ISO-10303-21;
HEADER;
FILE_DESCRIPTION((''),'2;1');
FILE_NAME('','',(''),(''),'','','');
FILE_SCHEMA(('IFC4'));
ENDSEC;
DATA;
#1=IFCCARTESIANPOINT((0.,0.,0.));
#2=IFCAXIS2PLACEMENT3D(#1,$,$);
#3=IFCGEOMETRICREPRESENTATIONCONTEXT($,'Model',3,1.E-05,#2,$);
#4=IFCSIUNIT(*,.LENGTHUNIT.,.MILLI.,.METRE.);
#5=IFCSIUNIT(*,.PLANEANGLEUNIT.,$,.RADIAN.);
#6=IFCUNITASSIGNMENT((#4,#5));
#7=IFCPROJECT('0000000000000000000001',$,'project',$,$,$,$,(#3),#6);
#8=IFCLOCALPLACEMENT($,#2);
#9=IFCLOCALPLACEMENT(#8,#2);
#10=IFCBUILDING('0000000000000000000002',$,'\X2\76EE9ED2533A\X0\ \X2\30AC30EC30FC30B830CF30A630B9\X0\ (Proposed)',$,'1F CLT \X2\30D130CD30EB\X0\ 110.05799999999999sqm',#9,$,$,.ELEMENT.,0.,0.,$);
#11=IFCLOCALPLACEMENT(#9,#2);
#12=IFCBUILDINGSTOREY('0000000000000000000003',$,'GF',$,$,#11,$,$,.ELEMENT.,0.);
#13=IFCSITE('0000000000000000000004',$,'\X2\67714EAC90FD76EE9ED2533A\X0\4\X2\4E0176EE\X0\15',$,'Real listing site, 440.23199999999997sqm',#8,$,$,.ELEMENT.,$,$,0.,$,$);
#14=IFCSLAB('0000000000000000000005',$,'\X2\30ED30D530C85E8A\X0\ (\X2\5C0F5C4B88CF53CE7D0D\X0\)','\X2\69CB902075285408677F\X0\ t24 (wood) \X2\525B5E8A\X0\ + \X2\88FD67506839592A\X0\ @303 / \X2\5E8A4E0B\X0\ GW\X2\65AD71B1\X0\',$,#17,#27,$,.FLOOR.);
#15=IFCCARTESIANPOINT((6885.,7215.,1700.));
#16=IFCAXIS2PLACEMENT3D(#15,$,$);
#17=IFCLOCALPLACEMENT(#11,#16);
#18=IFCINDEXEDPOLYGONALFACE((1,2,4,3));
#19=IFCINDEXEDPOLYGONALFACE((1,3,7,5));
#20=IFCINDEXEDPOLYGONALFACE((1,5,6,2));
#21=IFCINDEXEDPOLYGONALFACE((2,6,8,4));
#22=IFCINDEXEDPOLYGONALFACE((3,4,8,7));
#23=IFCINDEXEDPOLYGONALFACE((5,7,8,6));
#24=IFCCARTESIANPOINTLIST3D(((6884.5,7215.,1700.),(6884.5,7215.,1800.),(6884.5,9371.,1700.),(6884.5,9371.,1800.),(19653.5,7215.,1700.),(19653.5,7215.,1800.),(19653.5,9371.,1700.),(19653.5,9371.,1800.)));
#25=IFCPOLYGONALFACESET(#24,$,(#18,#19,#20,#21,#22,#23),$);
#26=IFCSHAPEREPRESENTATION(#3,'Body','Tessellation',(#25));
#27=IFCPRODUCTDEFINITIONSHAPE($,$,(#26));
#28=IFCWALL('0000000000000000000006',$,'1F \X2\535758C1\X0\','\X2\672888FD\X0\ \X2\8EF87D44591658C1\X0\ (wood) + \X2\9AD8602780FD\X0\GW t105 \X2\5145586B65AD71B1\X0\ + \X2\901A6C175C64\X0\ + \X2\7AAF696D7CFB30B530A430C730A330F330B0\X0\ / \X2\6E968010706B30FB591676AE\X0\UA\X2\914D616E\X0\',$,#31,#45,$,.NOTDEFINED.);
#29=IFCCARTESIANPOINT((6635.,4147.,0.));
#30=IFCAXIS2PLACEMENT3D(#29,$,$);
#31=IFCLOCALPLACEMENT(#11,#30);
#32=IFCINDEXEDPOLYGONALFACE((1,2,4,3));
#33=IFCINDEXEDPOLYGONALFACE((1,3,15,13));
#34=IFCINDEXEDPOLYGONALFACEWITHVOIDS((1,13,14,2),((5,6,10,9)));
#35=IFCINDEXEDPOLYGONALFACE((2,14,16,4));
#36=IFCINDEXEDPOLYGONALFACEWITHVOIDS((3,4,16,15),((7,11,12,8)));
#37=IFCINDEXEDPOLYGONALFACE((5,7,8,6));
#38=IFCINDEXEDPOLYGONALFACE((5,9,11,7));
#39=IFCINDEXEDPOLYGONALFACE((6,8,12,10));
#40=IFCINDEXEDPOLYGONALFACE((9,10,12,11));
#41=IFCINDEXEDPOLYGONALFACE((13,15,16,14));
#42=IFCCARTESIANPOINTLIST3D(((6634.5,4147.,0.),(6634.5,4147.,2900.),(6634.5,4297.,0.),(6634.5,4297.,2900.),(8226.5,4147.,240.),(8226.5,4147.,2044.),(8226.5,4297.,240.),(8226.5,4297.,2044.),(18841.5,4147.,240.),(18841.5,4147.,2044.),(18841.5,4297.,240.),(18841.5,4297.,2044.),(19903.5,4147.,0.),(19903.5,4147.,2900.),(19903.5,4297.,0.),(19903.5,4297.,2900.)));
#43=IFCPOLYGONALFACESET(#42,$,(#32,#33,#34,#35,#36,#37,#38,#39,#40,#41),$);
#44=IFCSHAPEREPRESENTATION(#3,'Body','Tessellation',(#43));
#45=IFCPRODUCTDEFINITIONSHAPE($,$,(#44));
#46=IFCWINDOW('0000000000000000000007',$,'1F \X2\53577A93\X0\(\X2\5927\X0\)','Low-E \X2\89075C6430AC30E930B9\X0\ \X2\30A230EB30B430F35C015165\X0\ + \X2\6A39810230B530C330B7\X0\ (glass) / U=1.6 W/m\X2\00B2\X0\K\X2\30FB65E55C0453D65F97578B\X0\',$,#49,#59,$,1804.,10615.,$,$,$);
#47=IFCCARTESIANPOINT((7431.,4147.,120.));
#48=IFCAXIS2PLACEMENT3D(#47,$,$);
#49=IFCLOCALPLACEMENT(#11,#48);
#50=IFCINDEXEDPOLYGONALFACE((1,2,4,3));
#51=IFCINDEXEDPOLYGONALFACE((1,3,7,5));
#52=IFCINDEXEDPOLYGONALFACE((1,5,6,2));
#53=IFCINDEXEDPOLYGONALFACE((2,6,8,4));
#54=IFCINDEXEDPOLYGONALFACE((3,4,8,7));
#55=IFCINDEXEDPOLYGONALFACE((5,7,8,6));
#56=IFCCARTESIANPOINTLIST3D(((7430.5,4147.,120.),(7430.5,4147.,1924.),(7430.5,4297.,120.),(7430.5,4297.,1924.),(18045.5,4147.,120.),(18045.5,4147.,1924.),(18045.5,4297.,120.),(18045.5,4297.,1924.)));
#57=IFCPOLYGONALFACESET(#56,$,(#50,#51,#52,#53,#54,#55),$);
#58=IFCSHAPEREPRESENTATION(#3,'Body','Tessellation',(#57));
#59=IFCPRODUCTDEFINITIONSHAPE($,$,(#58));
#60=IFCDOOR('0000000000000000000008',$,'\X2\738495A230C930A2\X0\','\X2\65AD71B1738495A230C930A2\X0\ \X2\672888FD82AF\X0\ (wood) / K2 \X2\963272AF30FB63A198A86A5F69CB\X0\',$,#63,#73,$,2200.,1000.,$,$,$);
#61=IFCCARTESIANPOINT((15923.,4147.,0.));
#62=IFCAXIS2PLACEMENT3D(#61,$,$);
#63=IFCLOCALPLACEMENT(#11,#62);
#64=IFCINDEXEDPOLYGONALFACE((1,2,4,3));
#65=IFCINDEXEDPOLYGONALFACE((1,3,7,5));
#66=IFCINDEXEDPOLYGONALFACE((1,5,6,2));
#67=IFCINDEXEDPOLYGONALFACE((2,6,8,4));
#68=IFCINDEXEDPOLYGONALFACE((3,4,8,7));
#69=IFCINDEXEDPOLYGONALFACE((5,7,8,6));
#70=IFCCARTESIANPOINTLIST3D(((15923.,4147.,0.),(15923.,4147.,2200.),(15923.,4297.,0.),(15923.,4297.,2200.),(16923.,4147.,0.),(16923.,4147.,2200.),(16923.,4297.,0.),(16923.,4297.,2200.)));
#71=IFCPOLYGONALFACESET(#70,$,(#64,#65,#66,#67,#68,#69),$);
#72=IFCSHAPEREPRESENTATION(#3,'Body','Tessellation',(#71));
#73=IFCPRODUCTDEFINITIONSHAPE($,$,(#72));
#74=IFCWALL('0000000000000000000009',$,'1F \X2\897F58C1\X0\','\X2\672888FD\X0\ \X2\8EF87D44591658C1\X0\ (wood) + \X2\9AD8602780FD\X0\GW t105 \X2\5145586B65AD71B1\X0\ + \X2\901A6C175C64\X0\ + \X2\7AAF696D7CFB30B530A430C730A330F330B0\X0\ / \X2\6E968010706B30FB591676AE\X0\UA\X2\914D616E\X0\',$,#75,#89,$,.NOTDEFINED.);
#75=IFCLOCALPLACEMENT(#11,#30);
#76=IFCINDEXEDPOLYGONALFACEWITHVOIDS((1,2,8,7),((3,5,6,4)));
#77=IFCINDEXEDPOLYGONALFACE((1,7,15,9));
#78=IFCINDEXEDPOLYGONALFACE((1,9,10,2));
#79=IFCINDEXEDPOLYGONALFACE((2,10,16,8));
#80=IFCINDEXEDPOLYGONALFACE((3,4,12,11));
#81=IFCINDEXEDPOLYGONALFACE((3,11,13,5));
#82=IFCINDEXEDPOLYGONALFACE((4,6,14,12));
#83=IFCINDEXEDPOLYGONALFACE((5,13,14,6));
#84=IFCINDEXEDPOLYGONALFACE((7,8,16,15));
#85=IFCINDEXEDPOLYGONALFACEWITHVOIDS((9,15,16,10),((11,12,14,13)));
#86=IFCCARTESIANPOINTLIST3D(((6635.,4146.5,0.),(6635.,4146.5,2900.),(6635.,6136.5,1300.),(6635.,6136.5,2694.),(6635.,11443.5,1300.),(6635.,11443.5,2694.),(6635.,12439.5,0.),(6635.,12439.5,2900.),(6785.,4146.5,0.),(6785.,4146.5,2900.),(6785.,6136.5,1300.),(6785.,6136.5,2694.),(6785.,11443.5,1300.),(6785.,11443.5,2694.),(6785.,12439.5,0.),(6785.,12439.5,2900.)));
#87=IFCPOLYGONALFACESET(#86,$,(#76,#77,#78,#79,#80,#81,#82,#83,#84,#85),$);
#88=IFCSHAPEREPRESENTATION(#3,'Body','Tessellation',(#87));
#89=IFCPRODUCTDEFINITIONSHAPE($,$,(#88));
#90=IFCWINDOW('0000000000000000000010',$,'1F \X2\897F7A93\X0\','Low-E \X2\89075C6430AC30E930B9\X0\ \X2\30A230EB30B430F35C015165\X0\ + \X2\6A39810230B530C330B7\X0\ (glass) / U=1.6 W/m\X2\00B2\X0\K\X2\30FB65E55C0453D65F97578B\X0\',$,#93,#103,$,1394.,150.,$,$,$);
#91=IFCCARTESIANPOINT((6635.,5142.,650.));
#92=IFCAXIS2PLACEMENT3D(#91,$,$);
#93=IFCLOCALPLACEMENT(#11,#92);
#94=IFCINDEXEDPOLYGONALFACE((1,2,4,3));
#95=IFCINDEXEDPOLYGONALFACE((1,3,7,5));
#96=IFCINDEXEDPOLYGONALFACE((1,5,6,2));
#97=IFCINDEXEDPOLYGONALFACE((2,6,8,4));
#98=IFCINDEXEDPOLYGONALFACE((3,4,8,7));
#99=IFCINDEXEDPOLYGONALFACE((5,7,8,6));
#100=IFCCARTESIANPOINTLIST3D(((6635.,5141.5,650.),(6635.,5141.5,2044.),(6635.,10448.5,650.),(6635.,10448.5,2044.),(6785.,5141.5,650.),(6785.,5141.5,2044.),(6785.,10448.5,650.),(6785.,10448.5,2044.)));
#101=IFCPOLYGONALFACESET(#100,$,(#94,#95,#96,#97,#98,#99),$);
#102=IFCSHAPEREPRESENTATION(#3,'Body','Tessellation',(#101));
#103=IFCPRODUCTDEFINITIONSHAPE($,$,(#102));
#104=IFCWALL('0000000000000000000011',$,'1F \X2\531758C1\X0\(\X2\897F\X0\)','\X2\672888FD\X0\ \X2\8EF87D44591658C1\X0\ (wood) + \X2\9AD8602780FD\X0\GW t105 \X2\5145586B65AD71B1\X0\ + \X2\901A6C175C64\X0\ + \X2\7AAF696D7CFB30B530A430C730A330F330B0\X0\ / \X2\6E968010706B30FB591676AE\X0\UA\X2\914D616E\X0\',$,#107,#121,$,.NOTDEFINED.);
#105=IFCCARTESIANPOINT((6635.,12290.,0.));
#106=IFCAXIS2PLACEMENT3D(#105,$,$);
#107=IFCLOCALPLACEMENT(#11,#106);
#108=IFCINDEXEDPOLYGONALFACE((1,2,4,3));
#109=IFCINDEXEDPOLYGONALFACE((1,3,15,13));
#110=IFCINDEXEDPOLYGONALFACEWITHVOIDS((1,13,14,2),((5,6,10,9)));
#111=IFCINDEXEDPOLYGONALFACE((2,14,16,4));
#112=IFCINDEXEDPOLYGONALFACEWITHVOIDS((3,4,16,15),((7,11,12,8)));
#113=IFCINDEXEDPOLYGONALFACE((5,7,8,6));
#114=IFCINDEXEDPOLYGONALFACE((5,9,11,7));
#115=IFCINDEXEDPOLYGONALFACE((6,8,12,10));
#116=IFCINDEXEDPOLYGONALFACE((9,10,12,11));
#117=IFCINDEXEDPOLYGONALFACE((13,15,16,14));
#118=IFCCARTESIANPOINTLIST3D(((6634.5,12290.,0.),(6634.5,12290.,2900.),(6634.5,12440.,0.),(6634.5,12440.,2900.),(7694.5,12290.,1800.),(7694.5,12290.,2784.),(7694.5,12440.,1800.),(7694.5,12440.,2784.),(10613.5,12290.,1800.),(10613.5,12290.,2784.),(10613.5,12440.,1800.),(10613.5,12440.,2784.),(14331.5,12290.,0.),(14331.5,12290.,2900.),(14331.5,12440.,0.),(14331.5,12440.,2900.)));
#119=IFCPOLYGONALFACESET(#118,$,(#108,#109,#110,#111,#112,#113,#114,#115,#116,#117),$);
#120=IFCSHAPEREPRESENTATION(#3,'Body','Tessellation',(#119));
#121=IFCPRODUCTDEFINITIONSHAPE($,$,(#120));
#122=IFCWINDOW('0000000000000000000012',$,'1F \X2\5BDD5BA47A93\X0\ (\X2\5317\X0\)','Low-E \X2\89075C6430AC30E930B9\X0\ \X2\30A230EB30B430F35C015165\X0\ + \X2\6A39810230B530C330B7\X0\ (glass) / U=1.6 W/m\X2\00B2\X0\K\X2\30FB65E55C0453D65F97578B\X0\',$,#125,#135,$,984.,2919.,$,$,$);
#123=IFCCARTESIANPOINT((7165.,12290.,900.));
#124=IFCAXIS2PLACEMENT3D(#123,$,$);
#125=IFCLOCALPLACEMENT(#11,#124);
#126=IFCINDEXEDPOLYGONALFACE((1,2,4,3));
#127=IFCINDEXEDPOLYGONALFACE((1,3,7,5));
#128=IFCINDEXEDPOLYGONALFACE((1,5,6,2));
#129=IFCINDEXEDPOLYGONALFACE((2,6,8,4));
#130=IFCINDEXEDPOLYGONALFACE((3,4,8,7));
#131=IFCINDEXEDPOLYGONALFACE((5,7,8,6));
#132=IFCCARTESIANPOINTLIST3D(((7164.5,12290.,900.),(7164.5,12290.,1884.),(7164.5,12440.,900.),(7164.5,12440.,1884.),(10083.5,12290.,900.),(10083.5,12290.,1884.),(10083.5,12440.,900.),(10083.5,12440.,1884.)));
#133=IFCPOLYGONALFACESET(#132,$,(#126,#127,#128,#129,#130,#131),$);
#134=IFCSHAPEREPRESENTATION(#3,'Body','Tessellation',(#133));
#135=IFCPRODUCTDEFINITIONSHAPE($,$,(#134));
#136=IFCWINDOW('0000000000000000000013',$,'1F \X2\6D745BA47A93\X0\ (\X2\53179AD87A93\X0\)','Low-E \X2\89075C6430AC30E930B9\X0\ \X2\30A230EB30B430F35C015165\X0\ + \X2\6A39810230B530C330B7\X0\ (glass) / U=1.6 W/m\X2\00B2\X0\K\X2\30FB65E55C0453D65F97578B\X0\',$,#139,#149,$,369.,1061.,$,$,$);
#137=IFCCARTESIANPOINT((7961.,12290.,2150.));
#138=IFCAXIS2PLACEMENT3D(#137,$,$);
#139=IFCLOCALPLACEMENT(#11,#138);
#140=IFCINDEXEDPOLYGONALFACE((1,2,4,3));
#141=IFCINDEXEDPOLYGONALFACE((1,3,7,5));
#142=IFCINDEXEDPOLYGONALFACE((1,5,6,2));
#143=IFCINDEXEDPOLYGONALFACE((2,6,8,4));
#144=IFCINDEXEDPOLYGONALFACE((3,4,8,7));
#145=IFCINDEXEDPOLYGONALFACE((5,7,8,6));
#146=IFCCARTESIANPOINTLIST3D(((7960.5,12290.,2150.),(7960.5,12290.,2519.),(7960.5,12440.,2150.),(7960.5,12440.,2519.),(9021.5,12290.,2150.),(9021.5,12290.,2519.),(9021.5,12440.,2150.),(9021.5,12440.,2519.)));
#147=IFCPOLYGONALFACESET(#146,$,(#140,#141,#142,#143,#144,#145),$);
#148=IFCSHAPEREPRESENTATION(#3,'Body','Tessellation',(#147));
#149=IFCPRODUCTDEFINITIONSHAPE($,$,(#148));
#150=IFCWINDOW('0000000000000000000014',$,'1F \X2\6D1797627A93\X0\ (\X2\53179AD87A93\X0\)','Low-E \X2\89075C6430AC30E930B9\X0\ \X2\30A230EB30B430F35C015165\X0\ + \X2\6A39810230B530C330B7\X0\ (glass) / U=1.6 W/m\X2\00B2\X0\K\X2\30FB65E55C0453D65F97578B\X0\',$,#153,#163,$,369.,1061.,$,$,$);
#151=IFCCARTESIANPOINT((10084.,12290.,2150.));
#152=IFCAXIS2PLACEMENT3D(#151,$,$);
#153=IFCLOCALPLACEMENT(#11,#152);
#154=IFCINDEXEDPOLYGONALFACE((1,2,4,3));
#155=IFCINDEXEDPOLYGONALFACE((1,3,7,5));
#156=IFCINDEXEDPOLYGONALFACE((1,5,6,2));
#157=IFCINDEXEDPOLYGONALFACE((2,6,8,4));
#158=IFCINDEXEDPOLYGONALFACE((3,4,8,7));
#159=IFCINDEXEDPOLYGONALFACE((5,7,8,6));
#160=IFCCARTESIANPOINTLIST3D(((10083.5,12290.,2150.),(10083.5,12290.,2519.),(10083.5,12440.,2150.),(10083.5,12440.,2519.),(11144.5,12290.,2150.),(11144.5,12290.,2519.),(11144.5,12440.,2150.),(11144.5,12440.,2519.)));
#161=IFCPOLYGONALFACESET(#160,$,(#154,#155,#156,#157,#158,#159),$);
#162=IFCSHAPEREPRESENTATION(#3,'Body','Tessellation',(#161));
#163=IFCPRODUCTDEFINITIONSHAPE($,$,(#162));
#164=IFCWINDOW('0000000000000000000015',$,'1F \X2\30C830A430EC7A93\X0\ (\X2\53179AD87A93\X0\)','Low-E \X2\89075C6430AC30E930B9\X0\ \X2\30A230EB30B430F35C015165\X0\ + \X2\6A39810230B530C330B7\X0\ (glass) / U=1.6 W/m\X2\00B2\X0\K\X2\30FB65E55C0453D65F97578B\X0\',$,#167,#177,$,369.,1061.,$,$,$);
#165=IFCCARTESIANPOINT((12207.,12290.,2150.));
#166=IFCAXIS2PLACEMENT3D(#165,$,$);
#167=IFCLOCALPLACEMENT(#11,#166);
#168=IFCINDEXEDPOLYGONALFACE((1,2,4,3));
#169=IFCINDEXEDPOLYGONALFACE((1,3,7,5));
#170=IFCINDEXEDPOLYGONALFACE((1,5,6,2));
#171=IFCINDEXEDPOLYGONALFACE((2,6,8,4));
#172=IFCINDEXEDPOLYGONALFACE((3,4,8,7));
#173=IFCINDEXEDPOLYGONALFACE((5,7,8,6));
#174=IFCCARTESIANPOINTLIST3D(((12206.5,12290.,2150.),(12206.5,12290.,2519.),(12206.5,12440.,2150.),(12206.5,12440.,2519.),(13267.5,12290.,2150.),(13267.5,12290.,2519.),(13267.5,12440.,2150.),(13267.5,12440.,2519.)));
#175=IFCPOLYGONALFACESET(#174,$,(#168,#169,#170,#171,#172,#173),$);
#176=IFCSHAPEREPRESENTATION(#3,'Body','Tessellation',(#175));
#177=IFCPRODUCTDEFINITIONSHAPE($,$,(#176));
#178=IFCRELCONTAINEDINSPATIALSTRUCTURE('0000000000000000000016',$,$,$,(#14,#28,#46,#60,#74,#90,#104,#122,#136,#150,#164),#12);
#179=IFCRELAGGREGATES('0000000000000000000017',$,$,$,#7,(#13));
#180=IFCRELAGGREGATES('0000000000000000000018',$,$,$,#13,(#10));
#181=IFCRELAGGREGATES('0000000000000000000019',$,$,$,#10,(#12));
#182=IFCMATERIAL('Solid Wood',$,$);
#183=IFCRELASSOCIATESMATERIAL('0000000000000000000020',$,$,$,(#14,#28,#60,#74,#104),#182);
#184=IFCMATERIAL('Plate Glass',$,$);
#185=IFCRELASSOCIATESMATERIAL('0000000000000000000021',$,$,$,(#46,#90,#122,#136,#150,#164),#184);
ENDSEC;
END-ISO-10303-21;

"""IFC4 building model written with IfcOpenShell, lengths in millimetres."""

from ifc_helpers import new_model, si_unit, frame, frame_2d, origin, place, context, project, spatial, rectangle, extrude, material, element, fill, save


model = new_model("IFC4")

# Units and contexts
model_context = context("Model", 3, precision=1e-05, world=origin())
ifc_project = project(units=[si_unit("LENGTHUNIT", "METRE", prefix="MILLI"), si_unit("PLANEANGLEUNIT", "RADIAN")], contexts=[model_context])

# Site, building, storey
site_placement = place(None, origin())
site = spatial("IfcSite", under=ifc_project, at=site_placement, Name="東京都目黒区4丁目15", ObjectType="Real listing site, 440.23199999999997sqm", CompositionType="ELEMENT", RefElevation=0.0)
building_placement = place(site_placement, origin())
building = spatial("IfcBuilding", under=site, at=building_placement, Name="目黒区 ガレージハウス (Proposed)", ObjectType="1F CLT パネル 110.05799999999999sqm", CompositionType="ELEMENT", ElevationOfRefHeight=0.0, ElevationOfTerrain=0.0)
storey_placement = place(building_placement, origin())
storey = spatial("IfcBuildingStorey", under=building, at=storey_placement, Name="GF", CompositionType="ELEMENT", Elevation=0.0)

# Slab
ifc_material_1 = material(Name="Solid Wood")
slab_1_placement = place(storey_placement, frame((6885.0, 7215.0, 1700.0)))
element("IfcSlab", 1, at=slab_1_placement, inside=storey, material=ifc_material_1, Name="ロフト床 (小屋裏収納)", Description="構造用合板 t24 (wood) 剛床 + 製材根太 @303 / 床下 GW断熱", PredefinedType="FLOOR", context=model_context, shape_type="SweptSolid", body=[
    extrude(rectangle(XDim=12769.0, YDim=2156.0, at=frame_2d((6384.0, 1078.0))), frame((6885.0, 7215.0, 1700.0)), (0.0, 0.0, 1.0), 100.0),
])

# Wall, openings, window, door
wall_1_placement = place(storey_placement, frame((6635.0, 4147.0, 0.0)))
wall_1 = element("IfcWall", 2, at=wall_1_placement, inside=storey, material=ifc_material_1, Name="1F 南壁", Description="木製 軸組外壁 (wood) + 高性能GW t105 充填断熱 + 通気層 + 窯業系サイディング / 準耐火・外皮UA配慮", PredefinedType="NOTDEFINED", context=model_context, shape_type="SweptSolid", body=[
    extrude(rectangle(XDim=13269.0, YDim=150.0, at=frame_2d((6634.0, 75.0))), frame((6635.0, 4147.0, 0.0)), (0.0, 0.0, 1.0), 2900.0),
])
opening_1_placement = place(storey_placement, frame((7431.0, 4147.0, 120.0)))
opening_1 = element("IfcOpeningElement", 3, at=opening_1_placement, cuts=wall_1, PredefinedType="NOTDEFINED", context=model_context, shape_type="SweptSolid", body=[
    extrude(rectangle(XDim=10615.0, YDim=150.0, at=frame_2d((5307.0, 75.0))), frame((7431.0, 4147.0, 120.0)), (0.0, 0.0, 1.0), 1804.0),
])
opening_2_placement = place(storey_placement, frame((15923.0, 4147.0, 0.0)))
opening_2 = element("IfcOpeningElement", 4, at=opening_2_placement, cuts=wall_1, PredefinedType="NOTDEFINED", context=model_context, shape_type="SweptSolid", body=[
    extrude(rectangle(XDim=1000.0, YDim=150.0, at=frame_2d((500.0, 75.0))), frame((15923.0, 4147.0, 0.0)), (0.0, 0.0, 1.0), 2200.0),
])
ifc_material_2 = material(Name="Plate Glass")
window_1_placement = place(storey_placement, frame((7431.0, 4147.0, 120.0)))
window_1 = element("IfcWindow", 5, at=window_1_placement, inside=storey, material=ifc_material_2, Name="1F 南窓(大)", Description="Low-E 複層ガラス アルゴン封入 + 樹脂サッシ (glass) / U=1.6 W/m²K・日射取得型", OverallHeight=1804.0, OverallWidth=10615.0, context=model_context, shape_type="SweptSolid", body=[
    extrude(rectangle(XDim=10615.0, YDim=150.0, at=frame_2d((5307.0, 75.0))), frame((7431.0, 4147.0, 120.0)), (0.0, 0.0, 1.0), 1804.0),
])
fill(opening_1, window_1)
door_1_placement = place(storey_placement, frame((15923.0, 4147.0, 0.0)))
door_1 = element("IfcDoor", 6, at=door_1_placement, inside=storey, material=ifc_material_1, Name="玄関ドア", Description="断熱玄関ドア 木製芯 (wood) / K2 防犯・採風機構", OverallHeight=2200.0, OverallWidth=1000.0, context=model_context, shape_type="SweptSolid", body=[
    extrude(rectangle(XDim=1000.0, YDim=150.0, at=frame_2d((500.0, 75.0))), frame((15923.0, 4147.0, 0.0)), (0.0, 0.0, 1.0), 2200.0),
])
fill(opening_2, door_1)

# Wall, opening, window
wall_2_placement = place(storey_placement, frame((6635.0, 4147.0, 0.0)))
wall_2 = element("IfcWall", 7, at=wall_2_placement, inside=storey, material=ifc_material_1, Name="1F 西壁", Description="木製 軸組外壁 (wood) + 高性能GW t105 充填断熱 + 通気層 + 窯業系サイディング / 準耐火・外皮UA配慮", PredefinedType="NOTDEFINED", context=model_context, shape_type="SweptSolid", body=[
    extrude(rectangle(XDim=150.0, YDim=8293.0, at=frame_2d((75.0, 4146.0))), frame((6635.0, 4147.0, 0.0)), (0.0, 0.0, 1.0), 2900.0),
])
opening_3_placement = place(storey_placement, frame((6635.0, 5142.0, 650.0)))
opening_3 = element("IfcOpeningElement", 8, at=opening_3_placement, cuts=wall_2, PredefinedType="NOTDEFINED", context=model_context, shape_type="SweptSolid", body=[
    extrude(rectangle(XDim=150.0, YDim=5307.0, at=frame_2d((75.0, 2653.0))), frame((6635.0, 5142.0, 650.0)), (0.0, 0.0, 1.0), 1394.0),
])
window_2_placement = place(storey_placement, frame((6635.0, 5142.0, 650.0)))
window_2 = element("IfcWindow", 9, at=window_2_placement, inside=storey, material=ifc_material_2, Name="1F 西窓", Description="Low-E 複層ガラス アルゴン封入 + 樹脂サッシ (glass) / U=1.6 W/m²K・日射取得型", OverallHeight=1394.0, OverallWidth=150.0, context=model_context, shape_type="SweptSolid", body=[
    extrude(rectangle(XDim=150.0, YDim=5307.0, at=frame_2d((75.0, 2653.0))), frame((6635.0, 5142.0, 650.0)), (0.0, 0.0, 1.0), 1394.0),
])
fill(opening_3, window_2)

# Wall, openings, windows
wall_3_placement = place(storey_placement, frame((6635.0, 12290.0, 0.0)))
wall_3 = element("IfcWall", 10, at=wall_3_placement, inside=storey, material=ifc_material_1, Name="1F 北壁(西)", Description="木製 軸組外壁 (wood) + 高性能GW t105 充填断熱 + 通気層 + 窯業系サイディング / 準耐火・外皮UA配慮", PredefinedType="NOTDEFINED", context=model_context, shape_type="SweptSolid", body=[
    extrude(rectangle(XDim=7697.0, YDim=150.0, at=frame_2d((3848.0, 75.0))), frame((6635.0, 12290.0, 0.0)), (0.0, 0.0, 1.0), 2900.0),
])
opening_4_placement = place(storey_placement, frame((7165.0, 12290.0, 900.0)))
opening_4 = element("IfcOpeningElement", 11, at=opening_4_placement, cuts=wall_3, PredefinedType="NOTDEFINED", context=model_context, shape_type="SweptSolid", body=[
    extrude(rectangle(XDim=2919.0, YDim=150.0, at=frame_2d((1459.0, 75.0))), frame((7165.0, 12290.0, 900.0)), (0.0, 0.0, 1.0), 984.0),
])
opening_5_placement = place(storey_placement, frame((7961.0, 12290.0, 2150.0)))
opening_5 = element("IfcOpeningElement", 12, at=opening_5_placement, cuts=wall_3, PredefinedType="NOTDEFINED", context=model_context, shape_type="SweptSolid", body=[
    extrude(rectangle(XDim=1061.0, YDim=150.0, at=frame_2d((530.0, 75.0))), frame((7961.0, 12290.0, 2150.0)), (0.0, 0.0, 1.0), 369.0),
])
opening_6_placement = place(storey_placement, frame((10084.0, 12290.0, 2150.0)))
opening_6 = element("IfcOpeningElement", 13, at=opening_6_placement, cuts=wall_3, PredefinedType="NOTDEFINED", context=model_context, shape_type="SweptSolid", body=[
    extrude(rectangle(XDim=1061.0, YDim=150.0, at=frame_2d((530.0, 75.0))), frame((10084.0, 12290.0, 2150.0)), (0.0, 0.0, 1.0), 369.0),
])
opening_7_placement = place(storey_placement, frame((12207.0, 12290.0, 2150.0)))
opening_7 = element("IfcOpeningElement", 14, at=opening_7_placement, cuts=wall_3, PredefinedType="NOTDEFINED", context=model_context, shape_type="SweptSolid", body=[
    extrude(rectangle(XDim=1061.0, YDim=150.0, at=frame_2d((530.0, 75.0))), frame((12207.0, 12290.0, 2150.0)), (0.0, 0.0, 1.0), 369.0),
])
window_3_placement = place(storey_placement, frame((7165.0, 12290.0, 900.0)))
window_3 = element("IfcWindow", 15, at=window_3_placement, inside=storey, material=ifc_material_2, Name="1F 寝室窓 (北)", Description="Low-E 複層ガラス アルゴン封入 + 樹脂サッシ (glass) / U=1.6 W/m²K・日射取得型", OverallHeight=984.0, OverallWidth=2919.0, context=model_context, shape_type="SweptSolid", body=[
    extrude(rectangle(XDim=2919.0, YDim=150.0, at=frame_2d((1459.0, 75.0))), frame((7165.0, 12290.0, 900.0)), (0.0, 0.0, 1.0), 984.0),
])
fill(opening_4, window_3)
window_4_placement = place(storey_placement, frame((7961.0, 12290.0, 2150.0)))
window_4 = element("IfcWindow", 16, at=window_4_placement, inside=storey, material=ifc_material_2, Name="1F 浴室窓 (北高窓)", Description="Low-E 複層ガラス アルゴン封入 + 樹脂サッシ (glass) / U=1.6 W/m²K・日射取得型", OverallHeight=369.0, OverallWidth=1061.0, context=model_context, shape_type="SweptSolid", body=[
    extrude(rectangle(XDim=1061.0, YDim=150.0, at=frame_2d((530.0, 75.0))), frame((7961.0, 12290.0, 2150.0)), (0.0, 0.0, 1.0), 369.0),
])
fill(opening_5, window_4)
window_5_placement = place(storey_placement, frame((10084.0, 12290.0, 2150.0)))
window_5 = element("IfcWindow", 17, at=window_5_placement, inside=storey, material=ifc_material_2, Name="1F 洗面窓 (北高窓)", Description="Low-E 複層ガラス アルゴン封入 + 樹脂サッシ (glass) / U=1.6 W/m²K・日射取得型", OverallHeight=369.0, OverallWidth=1061.0, context=model_context, shape_type="SweptSolid", body=[
    extrude(rectangle(XDim=1061.0, YDim=150.0, at=frame_2d((530.0, 75.0))), frame((10084.0, 12290.0, 2150.0)), (0.0, 0.0, 1.0), 369.0),
])
fill(opening_6, window_5)
window_6_placement = place(storey_placement, frame((12207.0, 12290.0, 2150.0)))
window_6 = element("IfcWindow", 18, at=window_6_placement, inside=storey, material=ifc_material_2, Name="1F トイレ窓 (北高窓)", Description="Low-E 複層ガラス アルゴン封入 + 樹脂サッシ (glass) / U=1.6 W/m²K・日射取得型", OverallHeight=369.0, OverallWidth=1061.0, context=model_context, shape_type="SweptSolid", body=[
    extrude(rectangle(XDim=1061.0, YDim=150.0, at=frame_2d((530.0, 75.0))), frame((12207.0, 12290.0, 2150.0)), (0.0, 0.0, 1.0), 369.0),
])
fill(opening_7, window_6)

save(model, "model.ifc")
